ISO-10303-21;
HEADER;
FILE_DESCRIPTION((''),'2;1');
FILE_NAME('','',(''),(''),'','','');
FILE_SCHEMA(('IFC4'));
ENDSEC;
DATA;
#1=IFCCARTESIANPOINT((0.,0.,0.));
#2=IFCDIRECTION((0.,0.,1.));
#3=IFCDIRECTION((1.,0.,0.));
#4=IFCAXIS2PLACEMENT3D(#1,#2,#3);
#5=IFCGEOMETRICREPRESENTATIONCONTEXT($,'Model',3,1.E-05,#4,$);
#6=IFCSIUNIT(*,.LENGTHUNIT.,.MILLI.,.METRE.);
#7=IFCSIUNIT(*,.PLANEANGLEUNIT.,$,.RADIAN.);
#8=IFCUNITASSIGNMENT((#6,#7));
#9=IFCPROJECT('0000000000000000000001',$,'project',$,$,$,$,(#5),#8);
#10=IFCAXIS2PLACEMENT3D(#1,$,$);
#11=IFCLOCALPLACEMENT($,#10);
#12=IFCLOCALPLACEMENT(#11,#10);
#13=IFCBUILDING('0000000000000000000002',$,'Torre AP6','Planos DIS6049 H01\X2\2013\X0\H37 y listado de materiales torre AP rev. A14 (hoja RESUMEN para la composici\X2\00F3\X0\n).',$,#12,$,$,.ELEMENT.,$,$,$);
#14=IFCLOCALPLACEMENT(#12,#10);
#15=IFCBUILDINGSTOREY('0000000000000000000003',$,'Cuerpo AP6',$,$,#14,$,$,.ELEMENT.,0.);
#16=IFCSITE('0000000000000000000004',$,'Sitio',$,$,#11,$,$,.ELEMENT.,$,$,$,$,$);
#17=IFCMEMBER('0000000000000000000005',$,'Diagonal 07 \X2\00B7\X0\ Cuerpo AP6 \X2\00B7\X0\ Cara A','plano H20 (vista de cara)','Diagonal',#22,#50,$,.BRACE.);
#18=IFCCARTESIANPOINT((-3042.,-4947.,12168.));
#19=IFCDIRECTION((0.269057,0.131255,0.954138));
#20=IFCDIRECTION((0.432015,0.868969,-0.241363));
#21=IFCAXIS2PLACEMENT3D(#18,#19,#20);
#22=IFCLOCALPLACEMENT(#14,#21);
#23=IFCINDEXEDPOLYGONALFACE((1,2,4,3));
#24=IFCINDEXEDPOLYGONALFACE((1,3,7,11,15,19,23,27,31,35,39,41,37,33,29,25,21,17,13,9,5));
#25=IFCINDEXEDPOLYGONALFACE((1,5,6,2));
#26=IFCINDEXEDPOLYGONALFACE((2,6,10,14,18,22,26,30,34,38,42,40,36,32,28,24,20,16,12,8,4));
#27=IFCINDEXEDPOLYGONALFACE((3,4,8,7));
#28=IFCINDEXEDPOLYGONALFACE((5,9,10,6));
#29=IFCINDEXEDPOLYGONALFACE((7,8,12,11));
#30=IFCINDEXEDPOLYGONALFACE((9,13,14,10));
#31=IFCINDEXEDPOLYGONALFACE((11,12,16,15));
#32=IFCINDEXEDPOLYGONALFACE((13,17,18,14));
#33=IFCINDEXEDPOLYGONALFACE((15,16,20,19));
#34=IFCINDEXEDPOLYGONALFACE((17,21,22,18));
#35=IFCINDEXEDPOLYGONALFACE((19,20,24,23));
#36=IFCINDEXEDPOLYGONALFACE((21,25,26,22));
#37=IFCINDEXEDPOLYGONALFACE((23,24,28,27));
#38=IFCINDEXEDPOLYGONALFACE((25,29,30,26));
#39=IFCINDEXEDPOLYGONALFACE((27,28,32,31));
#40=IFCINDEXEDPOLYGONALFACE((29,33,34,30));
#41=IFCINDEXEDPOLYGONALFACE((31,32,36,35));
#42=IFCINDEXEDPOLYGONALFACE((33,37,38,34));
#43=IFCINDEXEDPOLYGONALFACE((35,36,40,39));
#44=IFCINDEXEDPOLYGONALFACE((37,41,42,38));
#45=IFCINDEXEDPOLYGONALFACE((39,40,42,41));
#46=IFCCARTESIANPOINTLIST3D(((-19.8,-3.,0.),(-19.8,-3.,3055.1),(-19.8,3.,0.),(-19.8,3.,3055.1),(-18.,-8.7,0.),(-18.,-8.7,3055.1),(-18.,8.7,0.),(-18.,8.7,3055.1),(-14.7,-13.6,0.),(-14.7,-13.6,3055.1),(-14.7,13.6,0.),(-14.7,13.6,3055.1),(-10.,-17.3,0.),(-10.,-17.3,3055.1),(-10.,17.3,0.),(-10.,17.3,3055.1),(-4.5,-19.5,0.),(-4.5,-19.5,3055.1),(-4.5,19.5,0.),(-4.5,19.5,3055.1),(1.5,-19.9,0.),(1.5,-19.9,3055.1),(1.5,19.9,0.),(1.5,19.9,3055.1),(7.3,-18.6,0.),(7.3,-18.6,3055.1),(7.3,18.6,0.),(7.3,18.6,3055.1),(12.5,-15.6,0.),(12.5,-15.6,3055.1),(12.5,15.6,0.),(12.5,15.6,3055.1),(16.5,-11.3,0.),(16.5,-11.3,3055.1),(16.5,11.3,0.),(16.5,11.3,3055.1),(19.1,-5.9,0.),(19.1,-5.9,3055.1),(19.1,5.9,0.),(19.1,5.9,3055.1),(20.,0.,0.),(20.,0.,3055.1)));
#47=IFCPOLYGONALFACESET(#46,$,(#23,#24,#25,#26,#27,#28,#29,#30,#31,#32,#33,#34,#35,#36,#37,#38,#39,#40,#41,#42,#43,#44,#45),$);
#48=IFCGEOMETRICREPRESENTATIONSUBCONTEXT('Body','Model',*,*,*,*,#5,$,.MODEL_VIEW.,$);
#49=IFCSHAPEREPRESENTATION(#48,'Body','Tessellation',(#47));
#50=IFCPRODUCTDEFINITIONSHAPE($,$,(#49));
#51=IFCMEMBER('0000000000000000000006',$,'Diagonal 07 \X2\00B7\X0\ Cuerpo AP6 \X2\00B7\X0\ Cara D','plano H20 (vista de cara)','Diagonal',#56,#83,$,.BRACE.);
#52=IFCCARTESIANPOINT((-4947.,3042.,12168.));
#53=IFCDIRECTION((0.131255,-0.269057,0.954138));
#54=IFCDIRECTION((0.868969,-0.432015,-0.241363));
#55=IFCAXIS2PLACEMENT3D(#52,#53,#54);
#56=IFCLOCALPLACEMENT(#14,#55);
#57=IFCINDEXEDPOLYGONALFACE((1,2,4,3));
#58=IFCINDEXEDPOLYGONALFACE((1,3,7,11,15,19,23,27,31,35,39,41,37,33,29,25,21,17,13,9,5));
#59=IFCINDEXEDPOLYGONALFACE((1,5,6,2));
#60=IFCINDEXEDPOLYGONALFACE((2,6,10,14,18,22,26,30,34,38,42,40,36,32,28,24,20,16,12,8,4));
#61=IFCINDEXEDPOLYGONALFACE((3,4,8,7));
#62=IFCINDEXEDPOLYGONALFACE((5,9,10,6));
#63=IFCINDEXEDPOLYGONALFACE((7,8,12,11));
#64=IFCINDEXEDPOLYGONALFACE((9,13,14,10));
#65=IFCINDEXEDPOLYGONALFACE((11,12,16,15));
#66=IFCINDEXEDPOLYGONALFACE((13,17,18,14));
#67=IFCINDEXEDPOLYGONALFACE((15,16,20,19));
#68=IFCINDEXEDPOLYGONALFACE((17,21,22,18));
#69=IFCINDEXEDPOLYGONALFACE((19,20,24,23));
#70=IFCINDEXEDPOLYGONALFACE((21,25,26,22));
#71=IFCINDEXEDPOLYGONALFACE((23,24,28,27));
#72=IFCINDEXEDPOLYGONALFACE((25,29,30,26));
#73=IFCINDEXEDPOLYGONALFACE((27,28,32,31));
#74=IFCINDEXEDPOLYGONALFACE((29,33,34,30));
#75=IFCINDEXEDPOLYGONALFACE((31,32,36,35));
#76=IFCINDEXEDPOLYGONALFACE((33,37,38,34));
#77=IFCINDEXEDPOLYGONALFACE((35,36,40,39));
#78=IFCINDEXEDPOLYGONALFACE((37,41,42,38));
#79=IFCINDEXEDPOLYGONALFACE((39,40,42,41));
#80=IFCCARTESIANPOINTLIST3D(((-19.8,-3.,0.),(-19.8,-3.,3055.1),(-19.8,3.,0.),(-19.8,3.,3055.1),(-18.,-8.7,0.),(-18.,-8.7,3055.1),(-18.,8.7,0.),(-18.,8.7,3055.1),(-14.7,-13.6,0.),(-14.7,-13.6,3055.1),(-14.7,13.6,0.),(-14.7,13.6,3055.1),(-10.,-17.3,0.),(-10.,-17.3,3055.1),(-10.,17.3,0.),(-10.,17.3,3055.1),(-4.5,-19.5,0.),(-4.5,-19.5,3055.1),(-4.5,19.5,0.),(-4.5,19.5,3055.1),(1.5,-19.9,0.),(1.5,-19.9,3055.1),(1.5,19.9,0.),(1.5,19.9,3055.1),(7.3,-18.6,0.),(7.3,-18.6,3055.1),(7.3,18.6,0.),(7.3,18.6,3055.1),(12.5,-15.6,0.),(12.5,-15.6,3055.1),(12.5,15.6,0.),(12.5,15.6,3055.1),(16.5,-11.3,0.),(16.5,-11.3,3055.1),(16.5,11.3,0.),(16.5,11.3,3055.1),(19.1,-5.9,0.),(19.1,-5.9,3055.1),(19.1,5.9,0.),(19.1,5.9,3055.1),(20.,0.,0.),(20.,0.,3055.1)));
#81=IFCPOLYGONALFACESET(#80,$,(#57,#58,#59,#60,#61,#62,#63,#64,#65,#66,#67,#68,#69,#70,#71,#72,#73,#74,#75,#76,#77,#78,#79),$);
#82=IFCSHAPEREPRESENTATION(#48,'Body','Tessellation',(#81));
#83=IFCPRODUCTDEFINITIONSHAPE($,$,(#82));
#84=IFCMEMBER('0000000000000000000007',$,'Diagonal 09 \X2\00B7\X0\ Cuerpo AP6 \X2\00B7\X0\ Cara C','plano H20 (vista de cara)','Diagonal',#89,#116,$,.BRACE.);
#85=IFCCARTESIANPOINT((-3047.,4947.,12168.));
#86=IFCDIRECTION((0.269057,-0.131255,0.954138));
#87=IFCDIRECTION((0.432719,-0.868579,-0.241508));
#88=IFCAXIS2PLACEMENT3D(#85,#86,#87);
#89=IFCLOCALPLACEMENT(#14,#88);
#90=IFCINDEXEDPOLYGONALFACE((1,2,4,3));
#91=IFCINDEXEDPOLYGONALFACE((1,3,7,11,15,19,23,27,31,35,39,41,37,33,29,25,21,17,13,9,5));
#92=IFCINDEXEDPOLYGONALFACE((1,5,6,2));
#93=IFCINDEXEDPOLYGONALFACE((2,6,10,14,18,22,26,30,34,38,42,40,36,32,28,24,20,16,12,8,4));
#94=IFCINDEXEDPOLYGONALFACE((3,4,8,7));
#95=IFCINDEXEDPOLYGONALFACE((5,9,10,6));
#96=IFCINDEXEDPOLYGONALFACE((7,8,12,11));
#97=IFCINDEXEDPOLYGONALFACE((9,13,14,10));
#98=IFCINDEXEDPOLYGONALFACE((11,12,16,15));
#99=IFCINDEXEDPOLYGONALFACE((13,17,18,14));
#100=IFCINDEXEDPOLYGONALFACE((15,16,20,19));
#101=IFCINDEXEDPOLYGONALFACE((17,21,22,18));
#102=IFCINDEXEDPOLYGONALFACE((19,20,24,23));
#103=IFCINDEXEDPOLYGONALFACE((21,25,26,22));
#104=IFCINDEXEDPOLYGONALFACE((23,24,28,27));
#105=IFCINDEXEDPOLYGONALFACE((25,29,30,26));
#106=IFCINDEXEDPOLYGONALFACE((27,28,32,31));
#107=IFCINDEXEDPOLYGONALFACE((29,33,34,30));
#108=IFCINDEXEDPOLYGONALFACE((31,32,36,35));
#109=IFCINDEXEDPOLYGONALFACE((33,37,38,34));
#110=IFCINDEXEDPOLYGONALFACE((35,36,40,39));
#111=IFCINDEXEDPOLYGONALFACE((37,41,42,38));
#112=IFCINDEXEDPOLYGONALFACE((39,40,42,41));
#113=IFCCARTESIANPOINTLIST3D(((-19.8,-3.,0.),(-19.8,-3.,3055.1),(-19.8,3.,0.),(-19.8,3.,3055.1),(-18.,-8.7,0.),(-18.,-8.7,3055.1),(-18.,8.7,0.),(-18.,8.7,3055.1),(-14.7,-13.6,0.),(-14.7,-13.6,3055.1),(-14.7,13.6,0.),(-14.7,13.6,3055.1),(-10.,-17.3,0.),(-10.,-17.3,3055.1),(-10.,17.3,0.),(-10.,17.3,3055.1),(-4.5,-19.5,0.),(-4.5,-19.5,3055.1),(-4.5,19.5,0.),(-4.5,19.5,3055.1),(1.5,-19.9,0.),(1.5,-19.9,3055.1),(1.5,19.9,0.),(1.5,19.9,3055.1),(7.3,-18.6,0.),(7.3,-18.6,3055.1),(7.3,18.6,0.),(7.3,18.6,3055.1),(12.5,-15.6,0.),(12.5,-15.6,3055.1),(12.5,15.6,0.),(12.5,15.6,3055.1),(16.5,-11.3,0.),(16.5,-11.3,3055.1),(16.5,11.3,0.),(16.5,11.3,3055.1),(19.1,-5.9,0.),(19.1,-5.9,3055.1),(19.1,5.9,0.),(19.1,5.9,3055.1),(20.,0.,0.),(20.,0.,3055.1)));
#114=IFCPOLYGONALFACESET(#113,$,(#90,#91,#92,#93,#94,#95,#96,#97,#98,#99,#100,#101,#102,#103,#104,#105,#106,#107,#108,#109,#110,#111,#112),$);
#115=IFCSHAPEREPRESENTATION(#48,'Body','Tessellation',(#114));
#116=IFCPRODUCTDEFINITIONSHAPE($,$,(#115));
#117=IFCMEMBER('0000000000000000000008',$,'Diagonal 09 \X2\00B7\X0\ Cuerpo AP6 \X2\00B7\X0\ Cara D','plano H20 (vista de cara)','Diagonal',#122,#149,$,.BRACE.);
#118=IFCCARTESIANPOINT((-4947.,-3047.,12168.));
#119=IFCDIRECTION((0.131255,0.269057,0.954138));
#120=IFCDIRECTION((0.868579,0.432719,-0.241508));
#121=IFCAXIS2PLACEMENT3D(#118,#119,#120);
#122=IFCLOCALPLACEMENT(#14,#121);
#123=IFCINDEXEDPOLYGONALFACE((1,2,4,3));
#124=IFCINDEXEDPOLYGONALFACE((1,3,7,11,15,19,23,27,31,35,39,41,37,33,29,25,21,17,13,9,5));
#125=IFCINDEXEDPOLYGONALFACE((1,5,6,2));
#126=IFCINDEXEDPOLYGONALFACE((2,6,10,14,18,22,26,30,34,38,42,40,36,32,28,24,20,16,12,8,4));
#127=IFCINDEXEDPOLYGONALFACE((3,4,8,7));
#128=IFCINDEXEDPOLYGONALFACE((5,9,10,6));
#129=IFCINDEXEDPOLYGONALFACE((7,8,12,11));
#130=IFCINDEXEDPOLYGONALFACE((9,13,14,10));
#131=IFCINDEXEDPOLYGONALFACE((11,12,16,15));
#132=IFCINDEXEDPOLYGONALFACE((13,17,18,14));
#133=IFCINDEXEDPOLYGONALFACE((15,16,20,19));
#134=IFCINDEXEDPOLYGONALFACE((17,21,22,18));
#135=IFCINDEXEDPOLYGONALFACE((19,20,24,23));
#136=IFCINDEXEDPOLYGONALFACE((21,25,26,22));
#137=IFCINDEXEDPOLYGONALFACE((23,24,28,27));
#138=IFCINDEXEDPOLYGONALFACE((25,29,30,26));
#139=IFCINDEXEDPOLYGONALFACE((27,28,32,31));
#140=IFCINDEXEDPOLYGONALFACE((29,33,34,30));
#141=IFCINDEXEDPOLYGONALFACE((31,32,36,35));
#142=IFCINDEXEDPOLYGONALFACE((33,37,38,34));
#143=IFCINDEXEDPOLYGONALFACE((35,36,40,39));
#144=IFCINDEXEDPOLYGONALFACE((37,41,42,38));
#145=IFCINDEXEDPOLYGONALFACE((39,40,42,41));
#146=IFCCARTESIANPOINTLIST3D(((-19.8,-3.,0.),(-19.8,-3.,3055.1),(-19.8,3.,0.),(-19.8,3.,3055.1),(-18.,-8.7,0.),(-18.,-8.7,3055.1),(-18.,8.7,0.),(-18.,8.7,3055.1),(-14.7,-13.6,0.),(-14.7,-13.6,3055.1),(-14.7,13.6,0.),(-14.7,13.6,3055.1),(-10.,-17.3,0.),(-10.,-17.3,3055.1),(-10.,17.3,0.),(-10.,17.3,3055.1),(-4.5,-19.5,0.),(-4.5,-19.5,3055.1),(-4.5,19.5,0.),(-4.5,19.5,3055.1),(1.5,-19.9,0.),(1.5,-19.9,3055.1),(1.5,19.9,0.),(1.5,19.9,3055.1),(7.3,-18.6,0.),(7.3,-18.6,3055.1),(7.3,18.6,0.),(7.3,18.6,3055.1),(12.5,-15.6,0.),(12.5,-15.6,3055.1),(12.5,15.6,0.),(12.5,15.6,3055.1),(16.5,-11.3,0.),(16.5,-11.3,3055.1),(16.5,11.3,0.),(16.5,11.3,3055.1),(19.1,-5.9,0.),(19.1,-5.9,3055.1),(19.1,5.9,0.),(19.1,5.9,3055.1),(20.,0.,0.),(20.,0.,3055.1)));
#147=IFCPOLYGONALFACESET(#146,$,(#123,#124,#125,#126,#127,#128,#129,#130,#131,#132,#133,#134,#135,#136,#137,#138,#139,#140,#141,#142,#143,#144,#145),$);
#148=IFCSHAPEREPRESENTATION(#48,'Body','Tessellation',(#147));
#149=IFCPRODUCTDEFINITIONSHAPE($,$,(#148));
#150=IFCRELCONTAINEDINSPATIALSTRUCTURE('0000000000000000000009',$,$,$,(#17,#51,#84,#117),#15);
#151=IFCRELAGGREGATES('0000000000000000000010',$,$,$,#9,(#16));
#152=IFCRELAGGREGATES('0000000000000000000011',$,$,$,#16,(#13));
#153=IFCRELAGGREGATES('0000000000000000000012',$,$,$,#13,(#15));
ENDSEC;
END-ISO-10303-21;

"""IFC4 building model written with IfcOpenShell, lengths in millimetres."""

from ifc_helpers import new_model, si_unit, frame, origin, origin_with_axes, place, context, subcontext, project, spatial, circle, extrude, element, save


model = new_model("IFC4")

# Units and contexts
model_context = context("Model", 3, precision=1e-05, world=origin_with_axes())
body_context = subcontext(model_context, "Body", "Model", "MODEL_VIEW")
ifc_project = project(units=[si_unit("LENGTHUNIT", "METRE", prefix="MILLI"), si_unit("PLANEANGLEUNIT", "RADIAN")], contexts=[model_context])

# Site, building, storey
site_placement = place(None, origin())
site = spatial("IfcSite", under=ifc_project, at=site_placement, Name="Sitio", CompositionType="ELEMENT")
building_placement = place(site_placement, origin())
building = spatial("IfcBuilding", under=site, at=building_placement, Name="Torre AP6", Description="Planos DIS6049 H01–H37 y listado de materiales torre AP rev. A14 (hoja RESUMEN para la composición).", CompositionType="ELEMENT")
storey_placement = place(building_placement, origin())
storey = spatial("IfcBuildingStorey", under=building, at=storey_placement, Name="Cuerpo AP6", CompositionType="ELEMENT", Elevation=0.0)

# Members
for number, where, z_axis, x_axis, name in (
    (1, (-3042.0, -4947.0, 12168.0), (0.269057, 0.131255, 0.954138), (0.432015, 0.868969, -0.241363), "Diagonal 07 · Cuerpo AP6 · Cara A"),
    (2, (-4947.0, 3042.0, 12168.0), (0.131255, -0.269057, 0.954138), (0.868969, -0.432015, -0.241363), "Diagonal 07 · Cuerpo AP6 · Cara D"),
):
    element("IfcMember", number, at=place(storey_placement, frame(where, z_axis=z_axis, x_axis=x_axis)), inside=storey, Name=name, Description="plano H20 (vista de cara)", ObjectType="Diagonal", PredefinedType="BRACE", context=body_context, shape_type="SweptSolid", body=[
        extrude(circle(Radius=20.0), None, (0.0, 0.0, 1.0), 3055.1),
    ])
for number, where, z_axis, x_axis, name in (
    (3, (-3047.0, 4947.0, 12168.0), (0.269057, -0.131255, 0.954138), (0.432719, -0.868579, -0.241508), "Diagonal 09 · Cuerpo AP6 · Cara C"),
    (4, (-4947.0, -3047.0, 12168.0), (0.131255, 0.269057, 0.954138), (0.868579, 0.432719, -0.241508), "Diagonal 09 · Cuerpo AP6 · Cara D"),
):
    element("IfcMember", number, at=place(storey_placement, frame(where, z_axis=z_axis, x_axis=x_axis)), inside=storey, Name=name, Description="plano H20 (vista de cara)", ObjectType="Diagonal", PredefinedType="BRACE", context=body_context, shape_type="SweptSolid", body=[
        extrude(circle(Radius=20.0), None, (0.0, 0.0, 1.0), 3055.1),
    ])

save(model, "model.ifc")
